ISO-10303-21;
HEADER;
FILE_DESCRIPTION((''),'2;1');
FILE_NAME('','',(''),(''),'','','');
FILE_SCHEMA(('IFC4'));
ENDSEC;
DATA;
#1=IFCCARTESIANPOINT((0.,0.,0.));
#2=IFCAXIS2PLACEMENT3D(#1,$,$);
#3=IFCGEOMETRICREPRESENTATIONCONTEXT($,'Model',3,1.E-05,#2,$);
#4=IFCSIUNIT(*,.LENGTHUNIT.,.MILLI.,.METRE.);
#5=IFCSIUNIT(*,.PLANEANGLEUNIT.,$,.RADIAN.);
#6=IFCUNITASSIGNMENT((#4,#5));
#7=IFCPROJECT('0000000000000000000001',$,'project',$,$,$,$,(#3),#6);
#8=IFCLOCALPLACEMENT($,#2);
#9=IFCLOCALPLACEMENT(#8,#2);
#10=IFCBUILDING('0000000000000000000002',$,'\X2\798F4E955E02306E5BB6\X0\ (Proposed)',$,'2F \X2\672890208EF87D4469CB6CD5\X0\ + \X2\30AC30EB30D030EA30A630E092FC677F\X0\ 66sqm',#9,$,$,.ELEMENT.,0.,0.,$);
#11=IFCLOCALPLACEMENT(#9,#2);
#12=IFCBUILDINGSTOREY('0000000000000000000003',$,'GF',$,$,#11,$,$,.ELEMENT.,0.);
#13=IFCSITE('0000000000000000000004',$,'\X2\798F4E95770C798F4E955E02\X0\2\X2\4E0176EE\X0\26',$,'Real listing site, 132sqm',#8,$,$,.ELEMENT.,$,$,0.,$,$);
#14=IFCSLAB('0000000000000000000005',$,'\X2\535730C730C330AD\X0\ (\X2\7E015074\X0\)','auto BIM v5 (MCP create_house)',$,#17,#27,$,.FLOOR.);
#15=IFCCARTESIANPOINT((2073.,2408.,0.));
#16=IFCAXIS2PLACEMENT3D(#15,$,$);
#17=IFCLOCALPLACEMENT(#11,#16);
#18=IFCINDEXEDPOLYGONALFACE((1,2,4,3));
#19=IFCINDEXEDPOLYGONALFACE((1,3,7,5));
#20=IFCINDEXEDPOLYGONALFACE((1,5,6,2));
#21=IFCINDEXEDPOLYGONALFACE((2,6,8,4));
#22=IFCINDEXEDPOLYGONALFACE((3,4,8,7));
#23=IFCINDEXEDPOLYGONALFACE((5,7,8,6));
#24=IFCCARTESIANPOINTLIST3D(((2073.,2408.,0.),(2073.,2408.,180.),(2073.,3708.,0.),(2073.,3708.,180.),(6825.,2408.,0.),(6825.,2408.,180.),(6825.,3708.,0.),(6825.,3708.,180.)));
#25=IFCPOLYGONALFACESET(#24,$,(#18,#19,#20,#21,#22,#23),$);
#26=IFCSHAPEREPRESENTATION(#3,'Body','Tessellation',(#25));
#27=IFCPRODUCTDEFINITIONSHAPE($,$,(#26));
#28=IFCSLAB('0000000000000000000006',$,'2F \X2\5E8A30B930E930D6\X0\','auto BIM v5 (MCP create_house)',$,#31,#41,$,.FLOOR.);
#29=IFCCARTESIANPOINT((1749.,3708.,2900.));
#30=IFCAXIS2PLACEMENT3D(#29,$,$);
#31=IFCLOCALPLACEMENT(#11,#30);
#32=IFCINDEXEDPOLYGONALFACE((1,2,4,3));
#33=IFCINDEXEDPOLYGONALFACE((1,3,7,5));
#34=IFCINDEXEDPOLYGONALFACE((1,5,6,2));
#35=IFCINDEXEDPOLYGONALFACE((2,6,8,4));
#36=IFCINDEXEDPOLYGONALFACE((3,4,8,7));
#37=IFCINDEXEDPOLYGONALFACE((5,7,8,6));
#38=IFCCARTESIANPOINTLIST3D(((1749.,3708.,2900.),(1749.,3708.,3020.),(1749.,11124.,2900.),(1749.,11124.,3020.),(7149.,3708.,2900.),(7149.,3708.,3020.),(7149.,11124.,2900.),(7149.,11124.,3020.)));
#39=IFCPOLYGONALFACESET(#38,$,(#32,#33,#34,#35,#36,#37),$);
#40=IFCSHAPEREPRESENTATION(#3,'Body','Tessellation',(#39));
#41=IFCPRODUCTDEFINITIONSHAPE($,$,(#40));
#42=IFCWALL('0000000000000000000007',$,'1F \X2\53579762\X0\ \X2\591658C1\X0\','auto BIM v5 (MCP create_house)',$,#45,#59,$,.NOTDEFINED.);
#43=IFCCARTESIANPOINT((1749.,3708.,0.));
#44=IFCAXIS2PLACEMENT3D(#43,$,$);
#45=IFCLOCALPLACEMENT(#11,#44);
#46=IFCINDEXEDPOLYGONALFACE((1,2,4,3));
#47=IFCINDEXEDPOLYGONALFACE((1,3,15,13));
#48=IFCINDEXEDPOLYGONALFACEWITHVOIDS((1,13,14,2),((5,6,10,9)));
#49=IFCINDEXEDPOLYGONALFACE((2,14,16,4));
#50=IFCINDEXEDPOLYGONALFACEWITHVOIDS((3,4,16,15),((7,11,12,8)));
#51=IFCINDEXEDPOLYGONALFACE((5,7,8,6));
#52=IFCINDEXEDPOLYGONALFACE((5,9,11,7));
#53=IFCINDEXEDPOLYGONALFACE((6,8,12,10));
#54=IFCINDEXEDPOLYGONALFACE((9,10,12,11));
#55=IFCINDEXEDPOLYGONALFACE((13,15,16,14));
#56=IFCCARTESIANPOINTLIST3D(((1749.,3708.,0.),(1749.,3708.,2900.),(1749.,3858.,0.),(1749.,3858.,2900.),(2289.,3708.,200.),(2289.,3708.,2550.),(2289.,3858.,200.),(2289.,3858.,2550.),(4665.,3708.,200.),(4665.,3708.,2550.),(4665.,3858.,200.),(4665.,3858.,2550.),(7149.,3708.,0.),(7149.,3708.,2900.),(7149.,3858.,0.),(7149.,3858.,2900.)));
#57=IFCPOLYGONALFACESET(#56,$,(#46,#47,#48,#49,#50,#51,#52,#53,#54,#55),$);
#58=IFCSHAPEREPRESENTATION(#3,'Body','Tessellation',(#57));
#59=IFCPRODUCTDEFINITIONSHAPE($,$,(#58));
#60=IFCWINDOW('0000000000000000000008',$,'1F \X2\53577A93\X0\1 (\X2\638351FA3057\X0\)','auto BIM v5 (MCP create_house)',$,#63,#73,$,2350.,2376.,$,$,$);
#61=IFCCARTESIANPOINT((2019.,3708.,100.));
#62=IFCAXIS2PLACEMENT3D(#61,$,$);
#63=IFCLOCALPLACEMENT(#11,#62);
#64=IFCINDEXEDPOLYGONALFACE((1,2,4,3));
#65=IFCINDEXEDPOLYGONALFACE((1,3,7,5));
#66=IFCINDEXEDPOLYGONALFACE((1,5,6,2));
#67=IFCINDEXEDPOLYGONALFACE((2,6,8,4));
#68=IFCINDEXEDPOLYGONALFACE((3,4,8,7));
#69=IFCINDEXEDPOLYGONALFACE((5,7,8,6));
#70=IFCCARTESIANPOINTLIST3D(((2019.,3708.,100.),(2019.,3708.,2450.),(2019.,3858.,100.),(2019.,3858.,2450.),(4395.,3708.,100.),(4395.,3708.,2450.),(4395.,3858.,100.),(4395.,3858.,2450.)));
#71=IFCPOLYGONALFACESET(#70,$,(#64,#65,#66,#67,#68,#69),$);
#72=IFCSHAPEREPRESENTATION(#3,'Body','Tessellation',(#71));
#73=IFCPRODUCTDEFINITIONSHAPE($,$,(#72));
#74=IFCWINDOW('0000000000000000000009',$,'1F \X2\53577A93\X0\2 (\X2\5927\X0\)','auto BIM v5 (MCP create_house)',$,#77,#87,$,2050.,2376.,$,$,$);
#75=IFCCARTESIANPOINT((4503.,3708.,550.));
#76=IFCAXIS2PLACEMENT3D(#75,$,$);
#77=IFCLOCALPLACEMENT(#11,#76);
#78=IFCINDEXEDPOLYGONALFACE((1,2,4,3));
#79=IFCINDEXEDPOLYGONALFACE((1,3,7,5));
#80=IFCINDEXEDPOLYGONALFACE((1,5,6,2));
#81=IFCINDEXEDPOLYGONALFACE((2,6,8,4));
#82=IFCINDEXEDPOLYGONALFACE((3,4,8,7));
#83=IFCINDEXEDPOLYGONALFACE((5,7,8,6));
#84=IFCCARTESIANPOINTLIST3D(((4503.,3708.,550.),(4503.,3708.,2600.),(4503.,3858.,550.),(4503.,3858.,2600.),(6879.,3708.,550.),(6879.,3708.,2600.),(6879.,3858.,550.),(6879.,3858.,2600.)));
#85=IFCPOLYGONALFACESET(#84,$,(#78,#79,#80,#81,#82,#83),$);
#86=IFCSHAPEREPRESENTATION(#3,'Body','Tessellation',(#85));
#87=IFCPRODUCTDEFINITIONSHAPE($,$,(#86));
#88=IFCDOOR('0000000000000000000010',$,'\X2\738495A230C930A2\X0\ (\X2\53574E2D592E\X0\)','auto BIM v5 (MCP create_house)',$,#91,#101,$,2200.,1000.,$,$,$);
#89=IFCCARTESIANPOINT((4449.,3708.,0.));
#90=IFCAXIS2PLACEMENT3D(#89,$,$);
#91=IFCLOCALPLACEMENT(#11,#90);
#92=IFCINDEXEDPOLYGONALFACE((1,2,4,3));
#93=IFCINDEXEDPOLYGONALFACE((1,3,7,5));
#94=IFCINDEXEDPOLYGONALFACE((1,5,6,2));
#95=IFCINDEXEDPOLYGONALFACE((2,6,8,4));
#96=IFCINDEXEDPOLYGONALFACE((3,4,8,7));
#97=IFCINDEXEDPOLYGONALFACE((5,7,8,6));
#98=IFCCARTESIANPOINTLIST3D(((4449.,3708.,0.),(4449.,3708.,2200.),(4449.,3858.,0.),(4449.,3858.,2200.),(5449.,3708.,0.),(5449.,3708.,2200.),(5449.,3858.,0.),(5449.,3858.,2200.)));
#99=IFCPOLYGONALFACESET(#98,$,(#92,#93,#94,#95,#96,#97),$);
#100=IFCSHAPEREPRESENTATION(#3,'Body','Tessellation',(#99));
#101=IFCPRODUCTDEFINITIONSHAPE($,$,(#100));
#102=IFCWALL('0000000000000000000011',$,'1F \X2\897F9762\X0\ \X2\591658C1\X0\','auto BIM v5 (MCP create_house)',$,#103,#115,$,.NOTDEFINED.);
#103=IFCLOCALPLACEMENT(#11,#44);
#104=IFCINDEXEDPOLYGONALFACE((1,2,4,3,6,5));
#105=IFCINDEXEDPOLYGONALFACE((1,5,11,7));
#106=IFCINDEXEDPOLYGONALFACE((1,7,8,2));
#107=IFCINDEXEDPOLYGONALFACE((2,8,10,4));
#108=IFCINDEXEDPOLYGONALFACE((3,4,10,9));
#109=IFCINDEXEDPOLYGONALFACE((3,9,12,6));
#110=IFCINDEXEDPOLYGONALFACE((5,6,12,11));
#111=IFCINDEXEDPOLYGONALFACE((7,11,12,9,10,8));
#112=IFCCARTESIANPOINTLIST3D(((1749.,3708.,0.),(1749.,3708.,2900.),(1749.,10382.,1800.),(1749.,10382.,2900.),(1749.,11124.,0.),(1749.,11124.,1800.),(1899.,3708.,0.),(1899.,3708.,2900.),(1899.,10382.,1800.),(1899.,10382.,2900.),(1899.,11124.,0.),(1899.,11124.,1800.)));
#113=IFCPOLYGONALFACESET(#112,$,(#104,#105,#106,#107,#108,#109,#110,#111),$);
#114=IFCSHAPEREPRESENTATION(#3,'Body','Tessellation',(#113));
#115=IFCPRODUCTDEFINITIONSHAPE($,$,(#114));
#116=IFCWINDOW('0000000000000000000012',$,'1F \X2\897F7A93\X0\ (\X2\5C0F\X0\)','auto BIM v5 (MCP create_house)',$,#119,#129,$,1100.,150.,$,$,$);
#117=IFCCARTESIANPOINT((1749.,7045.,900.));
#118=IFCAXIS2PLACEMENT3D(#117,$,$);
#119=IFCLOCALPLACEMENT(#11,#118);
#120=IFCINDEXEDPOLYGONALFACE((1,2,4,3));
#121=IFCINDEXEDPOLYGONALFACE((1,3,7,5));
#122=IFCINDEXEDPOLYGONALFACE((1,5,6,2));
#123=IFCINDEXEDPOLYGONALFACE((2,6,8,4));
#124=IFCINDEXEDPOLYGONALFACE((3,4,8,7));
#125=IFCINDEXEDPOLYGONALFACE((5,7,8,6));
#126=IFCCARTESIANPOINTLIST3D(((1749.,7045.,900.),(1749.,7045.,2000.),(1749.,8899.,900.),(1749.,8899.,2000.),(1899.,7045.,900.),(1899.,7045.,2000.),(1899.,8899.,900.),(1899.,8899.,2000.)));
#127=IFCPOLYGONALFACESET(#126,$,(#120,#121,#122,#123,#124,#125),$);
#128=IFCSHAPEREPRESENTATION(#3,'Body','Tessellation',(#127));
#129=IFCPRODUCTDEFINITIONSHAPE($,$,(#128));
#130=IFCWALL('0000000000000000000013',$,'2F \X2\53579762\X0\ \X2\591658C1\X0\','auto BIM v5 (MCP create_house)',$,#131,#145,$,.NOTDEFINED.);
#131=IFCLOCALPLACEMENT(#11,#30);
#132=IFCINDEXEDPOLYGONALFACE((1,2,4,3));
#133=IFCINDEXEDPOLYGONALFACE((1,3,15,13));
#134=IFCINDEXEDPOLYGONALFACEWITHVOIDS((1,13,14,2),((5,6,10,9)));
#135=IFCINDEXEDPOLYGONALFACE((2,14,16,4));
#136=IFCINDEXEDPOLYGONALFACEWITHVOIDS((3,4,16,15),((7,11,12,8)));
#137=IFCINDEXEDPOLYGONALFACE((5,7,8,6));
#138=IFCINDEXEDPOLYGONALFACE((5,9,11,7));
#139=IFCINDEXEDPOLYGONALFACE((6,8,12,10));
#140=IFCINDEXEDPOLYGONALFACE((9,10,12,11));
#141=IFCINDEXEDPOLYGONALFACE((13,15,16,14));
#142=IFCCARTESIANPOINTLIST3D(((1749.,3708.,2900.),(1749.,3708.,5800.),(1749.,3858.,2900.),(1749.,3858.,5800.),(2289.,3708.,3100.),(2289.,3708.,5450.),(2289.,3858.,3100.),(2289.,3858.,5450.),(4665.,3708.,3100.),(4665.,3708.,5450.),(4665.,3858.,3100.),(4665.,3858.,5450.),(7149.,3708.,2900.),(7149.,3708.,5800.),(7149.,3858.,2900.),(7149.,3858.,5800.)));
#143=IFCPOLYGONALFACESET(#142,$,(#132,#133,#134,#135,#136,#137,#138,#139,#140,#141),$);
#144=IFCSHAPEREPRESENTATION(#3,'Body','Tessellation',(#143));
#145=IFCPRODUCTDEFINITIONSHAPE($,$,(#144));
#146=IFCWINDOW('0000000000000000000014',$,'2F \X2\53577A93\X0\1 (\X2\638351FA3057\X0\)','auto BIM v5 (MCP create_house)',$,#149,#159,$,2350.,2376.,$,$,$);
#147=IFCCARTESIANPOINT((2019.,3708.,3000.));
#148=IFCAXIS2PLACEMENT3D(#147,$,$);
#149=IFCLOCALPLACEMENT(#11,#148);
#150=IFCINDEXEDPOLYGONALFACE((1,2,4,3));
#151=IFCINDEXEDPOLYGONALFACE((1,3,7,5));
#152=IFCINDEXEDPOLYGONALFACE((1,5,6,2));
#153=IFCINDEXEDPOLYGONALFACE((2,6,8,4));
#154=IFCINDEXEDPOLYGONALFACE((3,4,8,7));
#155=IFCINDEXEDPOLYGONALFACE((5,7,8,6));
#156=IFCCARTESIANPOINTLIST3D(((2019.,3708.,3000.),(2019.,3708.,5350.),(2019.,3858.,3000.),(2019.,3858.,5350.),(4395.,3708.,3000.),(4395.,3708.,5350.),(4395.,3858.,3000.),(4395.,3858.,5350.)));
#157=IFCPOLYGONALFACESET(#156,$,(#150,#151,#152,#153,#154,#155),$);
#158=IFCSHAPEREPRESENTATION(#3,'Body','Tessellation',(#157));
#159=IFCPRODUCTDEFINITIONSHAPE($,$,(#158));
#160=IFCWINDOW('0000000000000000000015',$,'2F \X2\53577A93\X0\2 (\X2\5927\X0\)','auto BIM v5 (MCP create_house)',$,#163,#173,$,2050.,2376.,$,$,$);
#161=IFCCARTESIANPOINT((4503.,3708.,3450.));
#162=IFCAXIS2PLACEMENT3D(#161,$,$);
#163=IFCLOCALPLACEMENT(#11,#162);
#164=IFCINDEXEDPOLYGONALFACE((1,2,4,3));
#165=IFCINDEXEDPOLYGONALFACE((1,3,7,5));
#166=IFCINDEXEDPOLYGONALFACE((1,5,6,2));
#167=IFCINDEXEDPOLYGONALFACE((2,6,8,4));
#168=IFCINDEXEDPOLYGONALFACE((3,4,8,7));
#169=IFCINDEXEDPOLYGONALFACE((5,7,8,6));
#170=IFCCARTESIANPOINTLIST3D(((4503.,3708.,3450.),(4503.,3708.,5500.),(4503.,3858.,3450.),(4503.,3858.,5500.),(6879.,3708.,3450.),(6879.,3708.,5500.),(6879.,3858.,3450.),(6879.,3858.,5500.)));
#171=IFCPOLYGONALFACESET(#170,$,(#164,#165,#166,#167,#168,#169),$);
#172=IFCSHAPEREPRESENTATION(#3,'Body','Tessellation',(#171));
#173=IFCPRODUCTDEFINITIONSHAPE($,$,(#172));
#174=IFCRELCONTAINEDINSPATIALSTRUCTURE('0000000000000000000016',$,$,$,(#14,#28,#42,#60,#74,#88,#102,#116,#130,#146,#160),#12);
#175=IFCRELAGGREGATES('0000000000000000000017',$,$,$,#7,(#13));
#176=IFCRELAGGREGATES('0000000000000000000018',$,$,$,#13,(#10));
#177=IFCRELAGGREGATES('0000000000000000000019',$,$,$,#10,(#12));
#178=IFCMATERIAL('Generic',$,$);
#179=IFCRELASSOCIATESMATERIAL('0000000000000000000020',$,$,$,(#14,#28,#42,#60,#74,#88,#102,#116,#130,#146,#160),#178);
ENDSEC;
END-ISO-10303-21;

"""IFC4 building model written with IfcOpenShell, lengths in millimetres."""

from ifc_helpers import new_model, si_unit, frame, frame_2d, origin, place, context, project, spatial, rectangle, extrude, material, element, fill, save


model = new_model("IFC4")

# Units and contexts
model_context = context("Model", 3, precision=1e-05, world=origin())
ifc_project = project(units=[si_unit("LENGTHUNIT", "METRE", prefix="MILLI"), si_unit("PLANEANGLEUNIT", "RADIAN")], contexts=[model_context])

# Site, building, storey
site_placement = place(None, origin())
site = spatial("IfcSite", under=ifc_project, at=site_placement, Name="福井県福井市2丁目26", ObjectType="Real listing site, 132sqm", CompositionType="ELEMENT", RefElevation=0.0)
building_placement = place(site_placement, origin())
building = spatial("IfcBuilding", under=site, at=building_placement, Name="福井市の家 (Proposed)", ObjectType="2F 木造軸組構法 + ガルバリウム鋼板 66sqm", CompositionType="ELEMENT", ElevationOfRefHeight=0.0, ElevationOfTerrain=0.0)
storey_placement = place(building_placement, origin())
storey = spatial("IfcBuildingStorey", under=building, at=storey_placement, Name="GF", CompositionType="ELEMENT", Elevation=0.0)

# Slabs
ifc_material = material(Name="Generic")
slab_1_placement = place(storey_placement, frame((2073.0, 2408.0, 0.0)))
element("IfcSlab", 1, at=slab_1_placement, inside=storey, material=ifc_material, Name="南デッキ (縁側)", Description="auto BIM v5 (MCP create_house)", PredefinedType="FLOOR", context=model_context, shape_type="SweptSolid", body=[
    extrude(rectangle(XDim=4752.0, YDim=1300.0, at=frame_2d((2376.0, 650.0))), frame((2073.0, 2408.0, 0.0)), (0.0, 0.0, 1.0), 180.0),
])
slab_2_placement = place(storey_placement, frame((1749.0, 3708.0, 2900.0)))
element("IfcSlab", 2, at=slab_2_placement, inside=storey, material=ifc_material, Name="2F 床スラブ", Description="auto BIM v5 (MCP create_house)", PredefinedType="FLOOR", context=model_context, shape_type="SweptSolid", body=[
    extrude(rectangle(XDim=5400.0, YDim=7416.0, at=frame_2d((2700.0, 3708.0))), frame((1749.0, 3708.0, 2900.0)), (0.0, 0.0, 1.0), 120.0),
])

# Wall, openings, windows, door
wall_1_placement = place(storey_placement, frame((1749.0, 3708.0, 0.0)))
wall_1 = element("IfcWall", 3, at=wall_1_placement, inside=storey, material=ifc_material, Name="1F 南面 外壁", Description="auto BIM v5 (MCP create_house)", PredefinedType="NOTDEFINED", context=model_context, shape_type="SweptSolid", body=[
    extrude(rectangle(XDim=5400.0, YDim=150.0, at=frame_2d((2700.0, 75.0))), frame((1749.0, 3708.0, 0.0)), (0.0, 0.0, 1.0), 2900.0),
])
opening_1_placement = place(storey_placement, frame((2019.0, 3708.0, 100.0)))
opening_1 = element("IfcOpeningElement", 4, at=opening_1_placement, cuts=wall_1, PredefinedType="NOTDEFINED", context=model_context, shape_type="SweptSolid", body=[
    extrude(rectangle(XDim=2376.0, YDim=150.0, at=frame_2d((1188.0, 75.0))), frame((2019.0, 3708.0, 100.0)), (0.0, 0.0, 1.0), 2350.0),
])
opening_2_placement = place(storey_placement, frame((4503.0, 3708.0, 550.0)))
opening_2 = element("IfcOpeningElement", 5, at=opening_2_placement, cuts=wall_1, PredefinedType="NOTDEFINED", context=model_context, shape_type="SweptSolid", body=[
    extrude(rectangle(XDim=2376.0, YDim=150.0, at=frame_2d((1188.0, 75.0))), frame((4503.0, 3708.0, 550.0)), (0.0, 0.0, 1.0), 2050.0),
])
opening_3_placement = place(storey_placement, frame((4449.0, 3708.0, 0.0)))
opening_3 = element("IfcOpeningElement", 6, at=opening_3_placement, cuts=wall_1, PredefinedType="NOTDEFINED", context=model_context, shape_type="SweptSolid", body=[
    extrude(rectangle(XDim=1000.0, YDim=150.0, at=frame_2d((500.0, 75.0))), frame((4449.0, 3708.0, 0.0)), (0.0, 0.0, 1.0), 2200.0),
])
window_1_placement = place(storey_placement, frame((2019.0, 3708.0, 100.0)))
window_1 = element("IfcWindow", 7, at=window_1_placement, inside=storey, material=ifc_material, Name="1F 南窓1 (掃出し)", Description="auto BIM v5 (MCP create_house)", OverallHeight=2350.0, OverallWidth=2376.0, context=model_context, shape_type="SweptSolid", body=[
    extrude(rectangle(XDim=2376.0, YDim=150.0, at=frame_2d((1188.0, 75.0))), frame((2019.0, 3708.0, 100.0)), (0.0, 0.0, 1.0), 2350.0),
])
fill(opening_1, window_1)
window_2_placement = place(storey_placement, frame((4503.0, 3708.0, 550.0)))
window_2 = element("IfcWindow", 8, at=window_2_placement, inside=storey, material=ifc_material, Name="1F 南窓2 (大)", Description="auto BIM v5 (MCP create_house)", OverallHeight=2050.0, OverallWidth=2376.0, context=model_context, shape_type="SweptSolid", body=[
    extrude(rectangle(XDim=2376.0, YDim=150.0, at=frame_2d((1188.0, 75.0))), frame((4503.0, 3708.0, 550.0)), (0.0, 0.0, 1.0), 2050.0),
])
fill(opening_2, window_2)
door_placement = place(storey_placement, frame((4449.0, 3708.0, 0.0)))
door = element("IfcDoor", 9, at=door_placement, inside=storey, material=ifc_material, Name="玄関ドア (南中央)", Description="auto BIM v5 (MCP create_house)", OverallHeight=2200.0, OverallWidth=1000.0, context=model_context, shape_type="SweptSolid", body=[
    extrude(rectangle(XDim=1000.0, YDim=150.0, at=frame_2d((500.0, 75.0))), frame((4449.0, 3708.0, 0.0)), (0.0, 0.0, 1.0), 2200.0),
])
fill(opening_3, door)

# Wall, opening, window
wall_2_placement = place(storey_placement, frame((1749.0, 3708.0, 0.0)))
wall_2 = element("IfcWall", 10, at=wall_2_placement, inside=storey, material=ifc_material, Name="1F 西面 外壁", Description="auto BIM v5 (MCP create_house)", PredefinedType="NOTDEFINED", context=model_context, shape_type="SweptSolid", body=[
    extrude(rectangle(XDim=150.0, YDim=7416.0, at=frame_2d((75.0, 3708.0))), frame((1749.0, 3708.0, 0.0)), (0.0, 0.0, 1.0), 2900.0),
])
opening_4_placement = place(storey_placement, frame((1749.0, 7045.0, 900.0)))
opening_4 = element("IfcOpeningElement", 11, at=opening_4_placement, cuts=wall_2, PredefinedType="NOTDEFINED", context=model_context, shape_type="SweptSolid", body=[
    extrude(rectangle(XDim=150.0, YDim=1854.0, at=frame_2d((75.0, 927.0))), frame((1749.0, 7045.0, 900.0)), (0.0, 0.0, 1.0), 1100.0),
])
window_3_placement = place(storey_placement, frame((1749.0, 7045.0, 900.0)))
window_3 = element("IfcWindow", 12, at=window_3_placement, inside=storey, material=ifc_material, Name="1F 西窓 (小)", Description="auto BIM v5 (MCP create_house)", OverallHeight=1100.0, OverallWidth=150.0, context=model_context, shape_type="SweptSolid", body=[
    extrude(rectangle(XDim=150.0, YDim=1854.0, at=frame_2d((75.0, 927.0))), frame((1749.0, 7045.0, 900.0)), (0.0, 0.0, 1.0), 1100.0),
])
fill(opening_4, window_3)

# Wall, openings, windows
wall_3_placement = place(storey_placement, frame((1749.0, 3708.0, 2900.0)))
wall_3 = element("IfcWall", 13, at=wall_3_placement, inside=storey, material=ifc_material, Name="2F 南面 外壁", Description="auto BIM v5 (MCP create_house)", PredefinedType="NOTDEFINED", context=model_context, shape_type="SweptSolid", body=[
    extrude(rectangle(XDim=5400.0, YDim=150.0, at=frame_2d((2700.0, 75.0))), frame((1749.0, 3708.0, 2900.0)), (0.0, 0.0, 1.0), 2900.0),
])
opening_5_placement = place(storey_placement, frame((2019.0, 3708.0, 3000.0)))
opening_5 = element("IfcOpeningElement", 14, at=opening_5_placement, cuts=wall_3, PredefinedType="NOTDEFINED", context=model_context, shape_type="SweptSolid", body=[
    extrude(rectangle(XDim=2376.0, YDim=150.0, at=frame_2d((1188.0, 75.0))), frame((2019.0, 3708.0, 3000.0)), (0.0, 0.0, 1.0), 2350.0),
])
opening_6_placement = place(storey_placement, frame((4503.0, 3708.0, 3450.0)))
opening_6 = element("IfcOpeningElement", 15, at=opening_6_placement, cuts=wall_3, PredefinedType="NOTDEFINED", context=model_context, shape_type="SweptSolid", body=[
    extrude(rectangle(XDim=2376.0, YDim=150.0, at=frame_2d((1188.0, 75.0))), frame((4503.0, 3708.0, 3450.0)), (0.0, 0.0, 1.0), 2050.0),
])
window_4_placement = place(storey_placement, frame((2019.0, 3708.0, 3000.0)))
window_4 = element("IfcWindow", 16, at=window_4_placement, inside=storey, material=ifc_material, Name="2F 南窓1 (掃出し)", Description="auto BIM v5 (MCP create_house)", OverallHeight=2350.0, OverallWidth=2376.0, context=model_context, shape_type="SweptSolid", body=[
    extrude(rectangle(XDim=2376.0, YDim=150.0, at=frame_2d((1188.0, 75.0))), frame((2019.0, 3708.0, 3000.0)), (0.0, 0.0, 1.0), 2350.0),
])
fill(opening_5, window_4)
window_5_placement = place(storey_placement, frame((4503.0, 3708.0, 3450.0)))
window_5 = element("IfcWindow", 17, at=window_5_placement, inside=storey, material=ifc_material, Name="2F 南窓2 (大)", Description="auto BIM v5 (MCP create_house)", OverallHeight=2050.0, OverallWidth=2376.0, context=model_context, shape_type="SweptSolid", body=[
    extrude(rectangle(XDim=2376.0, YDim=150.0, at=frame_2d((1188.0, 75.0))), frame((4503.0, 3708.0, 3450.0)), (0.0, 0.0, 1.0), 2050.0),
])
fill(opening_6, window_5)

save(model, "model.ifc")
